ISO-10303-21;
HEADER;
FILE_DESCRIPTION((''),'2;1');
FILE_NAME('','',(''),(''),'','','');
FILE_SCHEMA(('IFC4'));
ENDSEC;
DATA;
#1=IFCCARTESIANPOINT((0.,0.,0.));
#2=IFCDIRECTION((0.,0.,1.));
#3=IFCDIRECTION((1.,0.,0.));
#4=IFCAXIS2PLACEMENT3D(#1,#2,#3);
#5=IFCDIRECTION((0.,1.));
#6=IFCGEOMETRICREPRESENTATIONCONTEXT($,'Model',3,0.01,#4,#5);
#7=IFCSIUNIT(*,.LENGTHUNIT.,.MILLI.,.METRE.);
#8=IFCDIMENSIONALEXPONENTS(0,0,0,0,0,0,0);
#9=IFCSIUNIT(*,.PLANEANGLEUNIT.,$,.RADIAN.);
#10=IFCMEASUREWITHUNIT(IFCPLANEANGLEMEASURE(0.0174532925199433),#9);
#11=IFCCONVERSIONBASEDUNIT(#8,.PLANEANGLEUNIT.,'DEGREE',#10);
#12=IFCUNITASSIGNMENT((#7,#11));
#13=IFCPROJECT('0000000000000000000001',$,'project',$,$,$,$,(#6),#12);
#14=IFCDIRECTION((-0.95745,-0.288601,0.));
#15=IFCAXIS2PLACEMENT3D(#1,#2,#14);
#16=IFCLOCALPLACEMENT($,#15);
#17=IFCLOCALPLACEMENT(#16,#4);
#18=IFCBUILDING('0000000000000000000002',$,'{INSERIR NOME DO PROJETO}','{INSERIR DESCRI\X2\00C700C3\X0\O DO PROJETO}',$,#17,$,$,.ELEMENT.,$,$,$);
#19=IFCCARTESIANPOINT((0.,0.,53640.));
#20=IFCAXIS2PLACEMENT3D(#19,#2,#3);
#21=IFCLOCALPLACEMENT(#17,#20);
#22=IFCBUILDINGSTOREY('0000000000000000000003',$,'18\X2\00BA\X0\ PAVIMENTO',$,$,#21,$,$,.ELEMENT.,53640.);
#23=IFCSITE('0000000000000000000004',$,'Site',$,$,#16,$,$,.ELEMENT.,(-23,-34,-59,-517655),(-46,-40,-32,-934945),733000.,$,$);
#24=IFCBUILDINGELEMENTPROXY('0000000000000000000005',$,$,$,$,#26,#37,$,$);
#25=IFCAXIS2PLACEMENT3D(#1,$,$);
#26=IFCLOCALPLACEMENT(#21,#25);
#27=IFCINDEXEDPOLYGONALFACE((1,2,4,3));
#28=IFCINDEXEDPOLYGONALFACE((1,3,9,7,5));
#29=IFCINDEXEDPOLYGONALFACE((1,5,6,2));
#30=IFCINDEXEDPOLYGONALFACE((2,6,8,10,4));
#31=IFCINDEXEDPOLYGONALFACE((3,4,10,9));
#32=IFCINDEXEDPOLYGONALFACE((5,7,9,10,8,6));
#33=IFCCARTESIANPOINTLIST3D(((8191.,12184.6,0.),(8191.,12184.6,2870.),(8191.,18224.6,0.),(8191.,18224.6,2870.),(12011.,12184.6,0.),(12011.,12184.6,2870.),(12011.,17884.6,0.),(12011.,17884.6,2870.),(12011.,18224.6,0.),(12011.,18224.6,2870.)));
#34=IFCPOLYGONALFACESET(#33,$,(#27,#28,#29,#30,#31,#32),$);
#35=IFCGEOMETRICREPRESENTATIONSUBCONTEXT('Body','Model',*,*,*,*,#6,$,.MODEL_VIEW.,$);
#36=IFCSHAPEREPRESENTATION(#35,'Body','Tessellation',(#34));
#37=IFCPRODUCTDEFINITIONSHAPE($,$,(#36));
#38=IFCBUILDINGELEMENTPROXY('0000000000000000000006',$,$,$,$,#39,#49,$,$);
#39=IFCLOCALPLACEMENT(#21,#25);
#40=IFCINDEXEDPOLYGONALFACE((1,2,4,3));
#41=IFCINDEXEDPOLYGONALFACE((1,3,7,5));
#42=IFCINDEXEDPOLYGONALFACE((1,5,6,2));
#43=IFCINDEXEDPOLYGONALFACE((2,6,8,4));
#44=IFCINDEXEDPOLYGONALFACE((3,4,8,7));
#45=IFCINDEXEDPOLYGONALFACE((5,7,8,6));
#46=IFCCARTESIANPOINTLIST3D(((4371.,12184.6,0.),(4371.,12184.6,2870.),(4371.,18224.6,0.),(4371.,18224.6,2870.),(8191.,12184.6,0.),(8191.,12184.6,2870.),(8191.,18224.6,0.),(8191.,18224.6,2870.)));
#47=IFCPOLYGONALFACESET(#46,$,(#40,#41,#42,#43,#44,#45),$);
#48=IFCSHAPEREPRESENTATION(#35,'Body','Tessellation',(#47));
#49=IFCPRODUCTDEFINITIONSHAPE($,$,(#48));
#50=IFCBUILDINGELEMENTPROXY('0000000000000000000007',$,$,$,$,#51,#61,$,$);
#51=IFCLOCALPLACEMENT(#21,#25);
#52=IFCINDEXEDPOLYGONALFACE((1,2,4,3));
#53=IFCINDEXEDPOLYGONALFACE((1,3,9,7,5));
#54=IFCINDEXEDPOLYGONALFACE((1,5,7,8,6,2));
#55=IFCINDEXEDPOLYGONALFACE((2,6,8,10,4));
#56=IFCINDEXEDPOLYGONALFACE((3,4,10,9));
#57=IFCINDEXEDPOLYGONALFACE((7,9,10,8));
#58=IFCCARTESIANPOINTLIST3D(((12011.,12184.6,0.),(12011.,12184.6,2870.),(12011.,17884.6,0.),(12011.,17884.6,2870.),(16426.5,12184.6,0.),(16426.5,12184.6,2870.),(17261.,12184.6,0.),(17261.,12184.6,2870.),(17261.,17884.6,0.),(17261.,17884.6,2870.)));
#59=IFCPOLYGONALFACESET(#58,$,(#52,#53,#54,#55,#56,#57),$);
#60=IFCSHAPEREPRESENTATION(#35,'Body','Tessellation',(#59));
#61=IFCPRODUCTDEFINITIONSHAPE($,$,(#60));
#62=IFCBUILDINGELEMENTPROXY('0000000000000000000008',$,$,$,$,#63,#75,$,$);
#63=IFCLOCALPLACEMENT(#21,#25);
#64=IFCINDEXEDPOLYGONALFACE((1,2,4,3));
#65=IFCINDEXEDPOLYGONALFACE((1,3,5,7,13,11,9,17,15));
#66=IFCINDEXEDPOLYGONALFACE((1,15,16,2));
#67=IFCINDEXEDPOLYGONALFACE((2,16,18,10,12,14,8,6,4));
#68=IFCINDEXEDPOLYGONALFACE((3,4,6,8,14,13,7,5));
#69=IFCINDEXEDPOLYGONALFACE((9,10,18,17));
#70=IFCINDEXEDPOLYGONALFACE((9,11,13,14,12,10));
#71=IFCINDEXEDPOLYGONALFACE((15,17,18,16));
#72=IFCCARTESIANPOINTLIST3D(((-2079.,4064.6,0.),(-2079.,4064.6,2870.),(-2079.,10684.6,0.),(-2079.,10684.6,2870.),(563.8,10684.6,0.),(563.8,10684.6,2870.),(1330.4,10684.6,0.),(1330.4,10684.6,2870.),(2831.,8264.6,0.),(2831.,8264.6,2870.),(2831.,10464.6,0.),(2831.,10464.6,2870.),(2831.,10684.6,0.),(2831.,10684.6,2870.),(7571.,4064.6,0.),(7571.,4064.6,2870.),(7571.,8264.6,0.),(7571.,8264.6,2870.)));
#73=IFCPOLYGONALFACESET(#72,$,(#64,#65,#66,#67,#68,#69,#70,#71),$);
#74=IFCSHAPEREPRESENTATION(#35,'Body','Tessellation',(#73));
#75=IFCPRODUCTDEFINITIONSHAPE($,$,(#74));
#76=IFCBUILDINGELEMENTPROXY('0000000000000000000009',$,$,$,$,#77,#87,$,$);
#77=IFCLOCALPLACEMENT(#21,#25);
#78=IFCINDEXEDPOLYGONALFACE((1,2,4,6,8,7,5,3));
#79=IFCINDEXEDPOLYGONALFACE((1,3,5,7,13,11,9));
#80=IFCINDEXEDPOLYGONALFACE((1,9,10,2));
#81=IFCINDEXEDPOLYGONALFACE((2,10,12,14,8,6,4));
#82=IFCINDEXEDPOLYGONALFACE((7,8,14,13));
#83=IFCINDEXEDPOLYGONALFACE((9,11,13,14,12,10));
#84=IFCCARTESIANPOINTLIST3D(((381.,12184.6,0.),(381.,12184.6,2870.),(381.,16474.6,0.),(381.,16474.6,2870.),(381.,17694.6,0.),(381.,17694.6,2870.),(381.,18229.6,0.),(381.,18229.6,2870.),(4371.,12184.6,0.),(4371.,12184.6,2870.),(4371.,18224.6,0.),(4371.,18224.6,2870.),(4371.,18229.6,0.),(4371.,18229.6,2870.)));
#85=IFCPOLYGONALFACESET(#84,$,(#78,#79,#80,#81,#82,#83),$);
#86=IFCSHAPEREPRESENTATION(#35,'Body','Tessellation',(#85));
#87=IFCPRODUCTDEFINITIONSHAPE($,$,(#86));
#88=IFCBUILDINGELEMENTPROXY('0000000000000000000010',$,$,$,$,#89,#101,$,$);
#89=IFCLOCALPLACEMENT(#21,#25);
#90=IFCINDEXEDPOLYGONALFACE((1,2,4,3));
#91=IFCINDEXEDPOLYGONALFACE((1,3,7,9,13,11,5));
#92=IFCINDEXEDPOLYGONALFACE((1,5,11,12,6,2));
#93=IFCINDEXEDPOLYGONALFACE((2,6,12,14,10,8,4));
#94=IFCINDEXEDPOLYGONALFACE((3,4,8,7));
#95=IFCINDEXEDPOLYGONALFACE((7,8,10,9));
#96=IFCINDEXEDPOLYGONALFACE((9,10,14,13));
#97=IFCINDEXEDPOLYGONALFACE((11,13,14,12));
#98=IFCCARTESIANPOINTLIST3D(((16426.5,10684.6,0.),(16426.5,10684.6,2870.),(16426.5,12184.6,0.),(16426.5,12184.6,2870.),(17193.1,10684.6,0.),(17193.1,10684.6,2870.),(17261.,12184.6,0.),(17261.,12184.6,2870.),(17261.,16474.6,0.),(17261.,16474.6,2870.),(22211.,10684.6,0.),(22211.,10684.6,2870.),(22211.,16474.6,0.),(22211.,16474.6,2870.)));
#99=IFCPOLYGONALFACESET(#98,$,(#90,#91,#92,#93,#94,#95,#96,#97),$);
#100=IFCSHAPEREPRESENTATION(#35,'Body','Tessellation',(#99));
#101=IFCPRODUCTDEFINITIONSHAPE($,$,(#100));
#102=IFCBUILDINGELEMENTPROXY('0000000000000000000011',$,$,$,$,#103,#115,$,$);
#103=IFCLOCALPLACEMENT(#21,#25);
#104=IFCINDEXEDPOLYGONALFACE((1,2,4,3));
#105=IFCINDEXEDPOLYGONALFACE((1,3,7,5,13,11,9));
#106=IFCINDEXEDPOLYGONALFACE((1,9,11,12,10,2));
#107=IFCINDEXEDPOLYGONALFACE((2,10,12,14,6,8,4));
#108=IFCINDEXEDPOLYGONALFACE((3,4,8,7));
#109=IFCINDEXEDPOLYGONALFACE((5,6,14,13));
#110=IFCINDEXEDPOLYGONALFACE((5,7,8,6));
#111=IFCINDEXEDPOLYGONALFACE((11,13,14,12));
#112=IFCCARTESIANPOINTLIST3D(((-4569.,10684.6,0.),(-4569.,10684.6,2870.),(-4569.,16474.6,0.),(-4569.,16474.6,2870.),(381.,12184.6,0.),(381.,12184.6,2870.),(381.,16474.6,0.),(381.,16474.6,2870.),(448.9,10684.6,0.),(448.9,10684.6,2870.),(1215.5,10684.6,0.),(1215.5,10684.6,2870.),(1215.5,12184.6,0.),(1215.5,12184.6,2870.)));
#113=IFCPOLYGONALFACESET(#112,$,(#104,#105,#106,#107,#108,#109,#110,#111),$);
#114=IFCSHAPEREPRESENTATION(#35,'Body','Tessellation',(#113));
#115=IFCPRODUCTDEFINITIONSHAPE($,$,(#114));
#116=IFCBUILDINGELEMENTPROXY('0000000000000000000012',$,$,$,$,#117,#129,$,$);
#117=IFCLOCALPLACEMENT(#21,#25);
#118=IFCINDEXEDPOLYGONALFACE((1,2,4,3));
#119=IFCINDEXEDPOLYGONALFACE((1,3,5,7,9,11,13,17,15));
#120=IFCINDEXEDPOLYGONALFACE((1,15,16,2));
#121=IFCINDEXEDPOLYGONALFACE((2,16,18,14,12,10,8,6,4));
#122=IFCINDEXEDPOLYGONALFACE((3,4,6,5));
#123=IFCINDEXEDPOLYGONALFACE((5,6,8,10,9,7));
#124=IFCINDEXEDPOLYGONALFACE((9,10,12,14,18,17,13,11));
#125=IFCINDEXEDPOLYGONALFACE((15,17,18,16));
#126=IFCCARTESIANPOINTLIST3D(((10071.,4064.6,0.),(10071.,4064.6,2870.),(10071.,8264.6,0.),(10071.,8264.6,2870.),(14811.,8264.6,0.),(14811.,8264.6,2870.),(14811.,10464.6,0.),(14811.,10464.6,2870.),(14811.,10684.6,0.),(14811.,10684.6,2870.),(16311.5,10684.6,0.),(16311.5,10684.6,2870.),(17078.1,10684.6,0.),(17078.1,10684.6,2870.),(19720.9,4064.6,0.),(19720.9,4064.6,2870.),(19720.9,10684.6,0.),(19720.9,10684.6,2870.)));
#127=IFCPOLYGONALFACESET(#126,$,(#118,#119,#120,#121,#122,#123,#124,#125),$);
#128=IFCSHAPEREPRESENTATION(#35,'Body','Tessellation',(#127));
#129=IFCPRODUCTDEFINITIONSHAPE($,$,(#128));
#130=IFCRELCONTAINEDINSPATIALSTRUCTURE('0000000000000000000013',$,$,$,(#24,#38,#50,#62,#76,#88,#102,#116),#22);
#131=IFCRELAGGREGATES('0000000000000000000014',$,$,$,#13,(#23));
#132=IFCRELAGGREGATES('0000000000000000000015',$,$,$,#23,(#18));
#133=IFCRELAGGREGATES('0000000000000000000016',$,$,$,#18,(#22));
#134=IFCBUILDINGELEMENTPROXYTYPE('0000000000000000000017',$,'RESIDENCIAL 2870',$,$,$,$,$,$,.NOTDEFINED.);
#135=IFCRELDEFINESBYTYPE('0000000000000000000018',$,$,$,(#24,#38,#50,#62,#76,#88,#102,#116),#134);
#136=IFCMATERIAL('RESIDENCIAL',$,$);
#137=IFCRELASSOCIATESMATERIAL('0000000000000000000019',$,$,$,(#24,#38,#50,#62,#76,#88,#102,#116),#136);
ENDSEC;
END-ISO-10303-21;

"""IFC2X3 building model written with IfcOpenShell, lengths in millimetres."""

from ifc_helpers import new_model, entity, si_unit, converted_unit, direction, frame, origin_with_axes, place, context, subcontext, project, spatial, polyline, outline, extrude, material, type_object, element, save


model = new_model("IFC2X3")

# Units and contexts
model_context = context("Model", 3, precision=0.01, world=origin_with_axes(), true_north=direction((0.0, 1.0)))
body_context = subcontext(model_context, "Body", "Model", "MODEL_VIEW")
ifc_project = project(units=[si_unit("LENGTHUNIT", "METRE", prefix="MILLI"), converted_unit("PLANEANGLEUNIT", "DEGREE", entity("IfcPlaneAngleMeasure", 0.0174532925199433), si_unit("PLANEANGLEUNIT", "RADIAN"), dimensions=[0, 0, 0, 0, 0, 0, 0])], contexts=[model_context])

# Site, building, storey
site_placement = place(None, frame((0.0, 0.0, 0.0), z_axis=(0.0, 0.0, 1.0), x_axis=(-0.95745, -0.288601, 0.0)))
site = spatial("IfcSite", under=ifc_project, at=site_placement, Name="Site", CompositionType="ELEMENT", RefLatitude=(-23, -34, -59, -517655), RefLongitude=(-46, -40, -32, -934945), RefElevation=733000.0)
building_placement = place(site_placement, origin_with_axes())
building = spatial("IfcBuilding", under=site, at=building_placement, Name="{INSERIR NOME DO PROJETO}", Description="{INSERIR DESCRIÇÃO DO PROJETO}", CompositionType="ELEMENT")
storey_placement = place(building_placement, frame((0.0, 0.0, 53640.0), z_axis=(0.0, 0.0, 1.0), x_axis=(1.0, 0.0, 0.0)))
storey = spatial("IfcBuildingStorey", under=building, at=storey_placement, Name="18º PAVIMENTO", CompositionType="ELEMENT", Elevation=53640.0)

# Building element proxies
ifc_material_1 = material(Name="RESIDENCIAL")
building_element_proxy_type_1 = type_object("IfcBuildingElementProxyType", Name="RESIDENCIAL 2870", PredefinedType="NOTDEFINED")
proxy_1_placement = place(storey_placement, frame((8191.0, 18224.6, 0.0), z_axis=(0.0, 0.0, 1.0), x_axis=(1.0, 0.0, 0.0)))
element("IfcBuildingElementProxy", 1, at=proxy_1_placement, inside=storey, type_object=building_element_proxy_type_1, material=ifc_material_1, context=body_context, shape_type="SweptSolid", body=[
    extrude(outline(polyline([(0.0, 0.0), (0.0, -6040.0), (3820.0, -6040.0), (3820.0, -340.0), (3820.0, 0.0), (0.0, 0.0)])), origin_with_axes(), (0.0, 0.0, 1.0), 2870.0),
])
proxy_2_placement = place(storey_placement, frame((4371.0, 18224.6, 0.0), z_axis=(0.0, 0.0, 1.0), x_axis=(1.0, 0.0, 0.0)))
element("IfcBuildingElementProxy", 2, at=proxy_2_placement, inside=storey, type_object=building_element_proxy_type_1, material=ifc_material_1, context=body_context, shape_type="SweptSolid", body=[
    extrude(outline(polyline([(0.0, 0.0), (0.0, -6040.0), (3820.0, -6040.0), (3820.0, 0.0), (0.0, 0.0)])), origin_with_axes(), (0.0, 0.0, 1.0), 2870.0),
])
proxy_3_placement = place(storey_placement, frame((12011.0, 12184.6, 0.0), z_axis=(0.0, 0.0, 1.0), x_axis=(1.0, 0.0, 0.0)))
element("IfcBuildingElementProxy", 3, at=proxy_3_placement, inside=storey, type_object=building_element_proxy_type_1, material=ifc_material_1, context=body_context, shape_type="SweptSolid", body=[
    extrude(outline(polyline([(0.0, 0.0), (4415.5, 0.0), (5250.0, 0.0), (5250.0, 5700.0), (0.0, 5700.0), (0.0, 0.0)])), origin_with_axes(), (0.0, 0.0, 1.0), 2870.0),
])
proxy_4_placement = place(storey_placement, frame((-2079.0, 4064.6, 0.0), z_axis=(0.0, 0.0, 1.0), x_axis=(1.0, 0.0, 0.0)))
element("IfcBuildingElementProxy", 4, at=proxy_4_placement, inside=storey, type_object=building_element_proxy_type_1, material=ifc_material_1, context=body_context, shape_type="SweptSolid", body=[
    extrude(outline(polyline([(0.0, 0.0), (9650.0, 0.0), (9650.0, 4200.0), (4910.0, 4200.0), (4910.0, 6400.0), (4910.0, 6620.0), (3409.4, 6620.0), (2642.8, 6620.0), (0.0, 6620.0), (0.0, 0.0)])), origin_with_axes(), (0.0, 0.0, 1.0), 2870.0),
])
proxy_5_placement = place(storey_placement, frame((381.0, 16474.6, 0.0), z_axis=(0.0, 0.0, 1.0), x_axis=(1.0, 0.0, 0.0)))
element("IfcBuildingElementProxy", 5, at=proxy_5_placement, inside=storey, type_object=building_element_proxy_type_1, material=ifc_material_1, context=body_context, shape_type="SweptSolid", body=[
    extrude(outline(polyline([(0.0, 0.0), (0.0, -4290.0), (3990.0, -4290.0), (3990.0, 1750.0), (3990.0, 1755.0), (0.0, 1755.0), (0.0, 1220.0), (0.0, 0.0)])), origin_with_axes(), (0.0, 0.0, 1.0), 2870.0),
])
proxy_6_placement = place(storey_placement, frame((17261.0, 12184.6, 0.0), z_axis=(0.0, 0.0, 1.0), x_axis=(1.0, 0.0, 0.0)))
element("IfcBuildingElementProxy", 6, at=proxy_6_placement, inside=storey, type_object=building_element_proxy_type_1, material=ifc_material_1, context=body_context, shape_type="SweptSolid", body=[
    extrude(outline(polyline([(0.0, 0.0), (-834.5, 0.0), (-834.5, -1500.0), (-67.9, -1500.0), (4950.0, -1500.0), (4950.0, 4290.0), (0.0, 4290.0), (0.0, 0.0)])), origin_with_axes(), (0.0, 0.0, 1.0), 2870.0),
])
proxy_7_placement = place(storey_placement, frame((-4569.0, 16474.6, 0.0), z_axis=(0.0, 0.0, 1.0), x_axis=(1.0, 0.0, 0.0)))
element("IfcBuildingElementProxy", 7, at=proxy_7_placement, inside=storey, type_object=building_element_proxy_type_1, material=ifc_material_1, context=body_context, shape_type="SweptSolid", body=[
    extrude(outline(polyline([(0.0, 0.0), (0.0, -5790.0), (5017.9, -5790.0), (5784.5, -5790.0), (5784.5, -4290.0), (4950.0, -4290.0), (4950.0, 0.0), (0.0, 0.0)])), origin_with_axes(), (0.0, 0.0, 1.0), 2870.0),
])
proxy_8_placement = place(storey_placement, frame((19720.9, 4064.6, 0.0), z_axis=(0.0, 0.0, 1.0), x_axis=(1.0, 0.0, 0.0)))
element("IfcBuildingElementProxy", 8, at=proxy_8_placement, inside=storey, type_object=building_element_proxy_type_1, material=ifc_material_1, context=body_context, shape_type="SweptSolid", body=[
    extrude(outline(polyline([(0.0, 0.0), (0.0, 6620.0), (-2642.8, 6620.0), (-3409.4, 6620.0), (-4910.0, 6620.0), (-4910.0, 6400.0), (-4910.0, 4200.0), (-9650.0, 4200.0), (-9650.0, 0.0), (0.0, 0.0)])), origin_with_axes(), (0.0, 0.0, 1.0), 2870.0),
])

save(model, "model.ifc")
